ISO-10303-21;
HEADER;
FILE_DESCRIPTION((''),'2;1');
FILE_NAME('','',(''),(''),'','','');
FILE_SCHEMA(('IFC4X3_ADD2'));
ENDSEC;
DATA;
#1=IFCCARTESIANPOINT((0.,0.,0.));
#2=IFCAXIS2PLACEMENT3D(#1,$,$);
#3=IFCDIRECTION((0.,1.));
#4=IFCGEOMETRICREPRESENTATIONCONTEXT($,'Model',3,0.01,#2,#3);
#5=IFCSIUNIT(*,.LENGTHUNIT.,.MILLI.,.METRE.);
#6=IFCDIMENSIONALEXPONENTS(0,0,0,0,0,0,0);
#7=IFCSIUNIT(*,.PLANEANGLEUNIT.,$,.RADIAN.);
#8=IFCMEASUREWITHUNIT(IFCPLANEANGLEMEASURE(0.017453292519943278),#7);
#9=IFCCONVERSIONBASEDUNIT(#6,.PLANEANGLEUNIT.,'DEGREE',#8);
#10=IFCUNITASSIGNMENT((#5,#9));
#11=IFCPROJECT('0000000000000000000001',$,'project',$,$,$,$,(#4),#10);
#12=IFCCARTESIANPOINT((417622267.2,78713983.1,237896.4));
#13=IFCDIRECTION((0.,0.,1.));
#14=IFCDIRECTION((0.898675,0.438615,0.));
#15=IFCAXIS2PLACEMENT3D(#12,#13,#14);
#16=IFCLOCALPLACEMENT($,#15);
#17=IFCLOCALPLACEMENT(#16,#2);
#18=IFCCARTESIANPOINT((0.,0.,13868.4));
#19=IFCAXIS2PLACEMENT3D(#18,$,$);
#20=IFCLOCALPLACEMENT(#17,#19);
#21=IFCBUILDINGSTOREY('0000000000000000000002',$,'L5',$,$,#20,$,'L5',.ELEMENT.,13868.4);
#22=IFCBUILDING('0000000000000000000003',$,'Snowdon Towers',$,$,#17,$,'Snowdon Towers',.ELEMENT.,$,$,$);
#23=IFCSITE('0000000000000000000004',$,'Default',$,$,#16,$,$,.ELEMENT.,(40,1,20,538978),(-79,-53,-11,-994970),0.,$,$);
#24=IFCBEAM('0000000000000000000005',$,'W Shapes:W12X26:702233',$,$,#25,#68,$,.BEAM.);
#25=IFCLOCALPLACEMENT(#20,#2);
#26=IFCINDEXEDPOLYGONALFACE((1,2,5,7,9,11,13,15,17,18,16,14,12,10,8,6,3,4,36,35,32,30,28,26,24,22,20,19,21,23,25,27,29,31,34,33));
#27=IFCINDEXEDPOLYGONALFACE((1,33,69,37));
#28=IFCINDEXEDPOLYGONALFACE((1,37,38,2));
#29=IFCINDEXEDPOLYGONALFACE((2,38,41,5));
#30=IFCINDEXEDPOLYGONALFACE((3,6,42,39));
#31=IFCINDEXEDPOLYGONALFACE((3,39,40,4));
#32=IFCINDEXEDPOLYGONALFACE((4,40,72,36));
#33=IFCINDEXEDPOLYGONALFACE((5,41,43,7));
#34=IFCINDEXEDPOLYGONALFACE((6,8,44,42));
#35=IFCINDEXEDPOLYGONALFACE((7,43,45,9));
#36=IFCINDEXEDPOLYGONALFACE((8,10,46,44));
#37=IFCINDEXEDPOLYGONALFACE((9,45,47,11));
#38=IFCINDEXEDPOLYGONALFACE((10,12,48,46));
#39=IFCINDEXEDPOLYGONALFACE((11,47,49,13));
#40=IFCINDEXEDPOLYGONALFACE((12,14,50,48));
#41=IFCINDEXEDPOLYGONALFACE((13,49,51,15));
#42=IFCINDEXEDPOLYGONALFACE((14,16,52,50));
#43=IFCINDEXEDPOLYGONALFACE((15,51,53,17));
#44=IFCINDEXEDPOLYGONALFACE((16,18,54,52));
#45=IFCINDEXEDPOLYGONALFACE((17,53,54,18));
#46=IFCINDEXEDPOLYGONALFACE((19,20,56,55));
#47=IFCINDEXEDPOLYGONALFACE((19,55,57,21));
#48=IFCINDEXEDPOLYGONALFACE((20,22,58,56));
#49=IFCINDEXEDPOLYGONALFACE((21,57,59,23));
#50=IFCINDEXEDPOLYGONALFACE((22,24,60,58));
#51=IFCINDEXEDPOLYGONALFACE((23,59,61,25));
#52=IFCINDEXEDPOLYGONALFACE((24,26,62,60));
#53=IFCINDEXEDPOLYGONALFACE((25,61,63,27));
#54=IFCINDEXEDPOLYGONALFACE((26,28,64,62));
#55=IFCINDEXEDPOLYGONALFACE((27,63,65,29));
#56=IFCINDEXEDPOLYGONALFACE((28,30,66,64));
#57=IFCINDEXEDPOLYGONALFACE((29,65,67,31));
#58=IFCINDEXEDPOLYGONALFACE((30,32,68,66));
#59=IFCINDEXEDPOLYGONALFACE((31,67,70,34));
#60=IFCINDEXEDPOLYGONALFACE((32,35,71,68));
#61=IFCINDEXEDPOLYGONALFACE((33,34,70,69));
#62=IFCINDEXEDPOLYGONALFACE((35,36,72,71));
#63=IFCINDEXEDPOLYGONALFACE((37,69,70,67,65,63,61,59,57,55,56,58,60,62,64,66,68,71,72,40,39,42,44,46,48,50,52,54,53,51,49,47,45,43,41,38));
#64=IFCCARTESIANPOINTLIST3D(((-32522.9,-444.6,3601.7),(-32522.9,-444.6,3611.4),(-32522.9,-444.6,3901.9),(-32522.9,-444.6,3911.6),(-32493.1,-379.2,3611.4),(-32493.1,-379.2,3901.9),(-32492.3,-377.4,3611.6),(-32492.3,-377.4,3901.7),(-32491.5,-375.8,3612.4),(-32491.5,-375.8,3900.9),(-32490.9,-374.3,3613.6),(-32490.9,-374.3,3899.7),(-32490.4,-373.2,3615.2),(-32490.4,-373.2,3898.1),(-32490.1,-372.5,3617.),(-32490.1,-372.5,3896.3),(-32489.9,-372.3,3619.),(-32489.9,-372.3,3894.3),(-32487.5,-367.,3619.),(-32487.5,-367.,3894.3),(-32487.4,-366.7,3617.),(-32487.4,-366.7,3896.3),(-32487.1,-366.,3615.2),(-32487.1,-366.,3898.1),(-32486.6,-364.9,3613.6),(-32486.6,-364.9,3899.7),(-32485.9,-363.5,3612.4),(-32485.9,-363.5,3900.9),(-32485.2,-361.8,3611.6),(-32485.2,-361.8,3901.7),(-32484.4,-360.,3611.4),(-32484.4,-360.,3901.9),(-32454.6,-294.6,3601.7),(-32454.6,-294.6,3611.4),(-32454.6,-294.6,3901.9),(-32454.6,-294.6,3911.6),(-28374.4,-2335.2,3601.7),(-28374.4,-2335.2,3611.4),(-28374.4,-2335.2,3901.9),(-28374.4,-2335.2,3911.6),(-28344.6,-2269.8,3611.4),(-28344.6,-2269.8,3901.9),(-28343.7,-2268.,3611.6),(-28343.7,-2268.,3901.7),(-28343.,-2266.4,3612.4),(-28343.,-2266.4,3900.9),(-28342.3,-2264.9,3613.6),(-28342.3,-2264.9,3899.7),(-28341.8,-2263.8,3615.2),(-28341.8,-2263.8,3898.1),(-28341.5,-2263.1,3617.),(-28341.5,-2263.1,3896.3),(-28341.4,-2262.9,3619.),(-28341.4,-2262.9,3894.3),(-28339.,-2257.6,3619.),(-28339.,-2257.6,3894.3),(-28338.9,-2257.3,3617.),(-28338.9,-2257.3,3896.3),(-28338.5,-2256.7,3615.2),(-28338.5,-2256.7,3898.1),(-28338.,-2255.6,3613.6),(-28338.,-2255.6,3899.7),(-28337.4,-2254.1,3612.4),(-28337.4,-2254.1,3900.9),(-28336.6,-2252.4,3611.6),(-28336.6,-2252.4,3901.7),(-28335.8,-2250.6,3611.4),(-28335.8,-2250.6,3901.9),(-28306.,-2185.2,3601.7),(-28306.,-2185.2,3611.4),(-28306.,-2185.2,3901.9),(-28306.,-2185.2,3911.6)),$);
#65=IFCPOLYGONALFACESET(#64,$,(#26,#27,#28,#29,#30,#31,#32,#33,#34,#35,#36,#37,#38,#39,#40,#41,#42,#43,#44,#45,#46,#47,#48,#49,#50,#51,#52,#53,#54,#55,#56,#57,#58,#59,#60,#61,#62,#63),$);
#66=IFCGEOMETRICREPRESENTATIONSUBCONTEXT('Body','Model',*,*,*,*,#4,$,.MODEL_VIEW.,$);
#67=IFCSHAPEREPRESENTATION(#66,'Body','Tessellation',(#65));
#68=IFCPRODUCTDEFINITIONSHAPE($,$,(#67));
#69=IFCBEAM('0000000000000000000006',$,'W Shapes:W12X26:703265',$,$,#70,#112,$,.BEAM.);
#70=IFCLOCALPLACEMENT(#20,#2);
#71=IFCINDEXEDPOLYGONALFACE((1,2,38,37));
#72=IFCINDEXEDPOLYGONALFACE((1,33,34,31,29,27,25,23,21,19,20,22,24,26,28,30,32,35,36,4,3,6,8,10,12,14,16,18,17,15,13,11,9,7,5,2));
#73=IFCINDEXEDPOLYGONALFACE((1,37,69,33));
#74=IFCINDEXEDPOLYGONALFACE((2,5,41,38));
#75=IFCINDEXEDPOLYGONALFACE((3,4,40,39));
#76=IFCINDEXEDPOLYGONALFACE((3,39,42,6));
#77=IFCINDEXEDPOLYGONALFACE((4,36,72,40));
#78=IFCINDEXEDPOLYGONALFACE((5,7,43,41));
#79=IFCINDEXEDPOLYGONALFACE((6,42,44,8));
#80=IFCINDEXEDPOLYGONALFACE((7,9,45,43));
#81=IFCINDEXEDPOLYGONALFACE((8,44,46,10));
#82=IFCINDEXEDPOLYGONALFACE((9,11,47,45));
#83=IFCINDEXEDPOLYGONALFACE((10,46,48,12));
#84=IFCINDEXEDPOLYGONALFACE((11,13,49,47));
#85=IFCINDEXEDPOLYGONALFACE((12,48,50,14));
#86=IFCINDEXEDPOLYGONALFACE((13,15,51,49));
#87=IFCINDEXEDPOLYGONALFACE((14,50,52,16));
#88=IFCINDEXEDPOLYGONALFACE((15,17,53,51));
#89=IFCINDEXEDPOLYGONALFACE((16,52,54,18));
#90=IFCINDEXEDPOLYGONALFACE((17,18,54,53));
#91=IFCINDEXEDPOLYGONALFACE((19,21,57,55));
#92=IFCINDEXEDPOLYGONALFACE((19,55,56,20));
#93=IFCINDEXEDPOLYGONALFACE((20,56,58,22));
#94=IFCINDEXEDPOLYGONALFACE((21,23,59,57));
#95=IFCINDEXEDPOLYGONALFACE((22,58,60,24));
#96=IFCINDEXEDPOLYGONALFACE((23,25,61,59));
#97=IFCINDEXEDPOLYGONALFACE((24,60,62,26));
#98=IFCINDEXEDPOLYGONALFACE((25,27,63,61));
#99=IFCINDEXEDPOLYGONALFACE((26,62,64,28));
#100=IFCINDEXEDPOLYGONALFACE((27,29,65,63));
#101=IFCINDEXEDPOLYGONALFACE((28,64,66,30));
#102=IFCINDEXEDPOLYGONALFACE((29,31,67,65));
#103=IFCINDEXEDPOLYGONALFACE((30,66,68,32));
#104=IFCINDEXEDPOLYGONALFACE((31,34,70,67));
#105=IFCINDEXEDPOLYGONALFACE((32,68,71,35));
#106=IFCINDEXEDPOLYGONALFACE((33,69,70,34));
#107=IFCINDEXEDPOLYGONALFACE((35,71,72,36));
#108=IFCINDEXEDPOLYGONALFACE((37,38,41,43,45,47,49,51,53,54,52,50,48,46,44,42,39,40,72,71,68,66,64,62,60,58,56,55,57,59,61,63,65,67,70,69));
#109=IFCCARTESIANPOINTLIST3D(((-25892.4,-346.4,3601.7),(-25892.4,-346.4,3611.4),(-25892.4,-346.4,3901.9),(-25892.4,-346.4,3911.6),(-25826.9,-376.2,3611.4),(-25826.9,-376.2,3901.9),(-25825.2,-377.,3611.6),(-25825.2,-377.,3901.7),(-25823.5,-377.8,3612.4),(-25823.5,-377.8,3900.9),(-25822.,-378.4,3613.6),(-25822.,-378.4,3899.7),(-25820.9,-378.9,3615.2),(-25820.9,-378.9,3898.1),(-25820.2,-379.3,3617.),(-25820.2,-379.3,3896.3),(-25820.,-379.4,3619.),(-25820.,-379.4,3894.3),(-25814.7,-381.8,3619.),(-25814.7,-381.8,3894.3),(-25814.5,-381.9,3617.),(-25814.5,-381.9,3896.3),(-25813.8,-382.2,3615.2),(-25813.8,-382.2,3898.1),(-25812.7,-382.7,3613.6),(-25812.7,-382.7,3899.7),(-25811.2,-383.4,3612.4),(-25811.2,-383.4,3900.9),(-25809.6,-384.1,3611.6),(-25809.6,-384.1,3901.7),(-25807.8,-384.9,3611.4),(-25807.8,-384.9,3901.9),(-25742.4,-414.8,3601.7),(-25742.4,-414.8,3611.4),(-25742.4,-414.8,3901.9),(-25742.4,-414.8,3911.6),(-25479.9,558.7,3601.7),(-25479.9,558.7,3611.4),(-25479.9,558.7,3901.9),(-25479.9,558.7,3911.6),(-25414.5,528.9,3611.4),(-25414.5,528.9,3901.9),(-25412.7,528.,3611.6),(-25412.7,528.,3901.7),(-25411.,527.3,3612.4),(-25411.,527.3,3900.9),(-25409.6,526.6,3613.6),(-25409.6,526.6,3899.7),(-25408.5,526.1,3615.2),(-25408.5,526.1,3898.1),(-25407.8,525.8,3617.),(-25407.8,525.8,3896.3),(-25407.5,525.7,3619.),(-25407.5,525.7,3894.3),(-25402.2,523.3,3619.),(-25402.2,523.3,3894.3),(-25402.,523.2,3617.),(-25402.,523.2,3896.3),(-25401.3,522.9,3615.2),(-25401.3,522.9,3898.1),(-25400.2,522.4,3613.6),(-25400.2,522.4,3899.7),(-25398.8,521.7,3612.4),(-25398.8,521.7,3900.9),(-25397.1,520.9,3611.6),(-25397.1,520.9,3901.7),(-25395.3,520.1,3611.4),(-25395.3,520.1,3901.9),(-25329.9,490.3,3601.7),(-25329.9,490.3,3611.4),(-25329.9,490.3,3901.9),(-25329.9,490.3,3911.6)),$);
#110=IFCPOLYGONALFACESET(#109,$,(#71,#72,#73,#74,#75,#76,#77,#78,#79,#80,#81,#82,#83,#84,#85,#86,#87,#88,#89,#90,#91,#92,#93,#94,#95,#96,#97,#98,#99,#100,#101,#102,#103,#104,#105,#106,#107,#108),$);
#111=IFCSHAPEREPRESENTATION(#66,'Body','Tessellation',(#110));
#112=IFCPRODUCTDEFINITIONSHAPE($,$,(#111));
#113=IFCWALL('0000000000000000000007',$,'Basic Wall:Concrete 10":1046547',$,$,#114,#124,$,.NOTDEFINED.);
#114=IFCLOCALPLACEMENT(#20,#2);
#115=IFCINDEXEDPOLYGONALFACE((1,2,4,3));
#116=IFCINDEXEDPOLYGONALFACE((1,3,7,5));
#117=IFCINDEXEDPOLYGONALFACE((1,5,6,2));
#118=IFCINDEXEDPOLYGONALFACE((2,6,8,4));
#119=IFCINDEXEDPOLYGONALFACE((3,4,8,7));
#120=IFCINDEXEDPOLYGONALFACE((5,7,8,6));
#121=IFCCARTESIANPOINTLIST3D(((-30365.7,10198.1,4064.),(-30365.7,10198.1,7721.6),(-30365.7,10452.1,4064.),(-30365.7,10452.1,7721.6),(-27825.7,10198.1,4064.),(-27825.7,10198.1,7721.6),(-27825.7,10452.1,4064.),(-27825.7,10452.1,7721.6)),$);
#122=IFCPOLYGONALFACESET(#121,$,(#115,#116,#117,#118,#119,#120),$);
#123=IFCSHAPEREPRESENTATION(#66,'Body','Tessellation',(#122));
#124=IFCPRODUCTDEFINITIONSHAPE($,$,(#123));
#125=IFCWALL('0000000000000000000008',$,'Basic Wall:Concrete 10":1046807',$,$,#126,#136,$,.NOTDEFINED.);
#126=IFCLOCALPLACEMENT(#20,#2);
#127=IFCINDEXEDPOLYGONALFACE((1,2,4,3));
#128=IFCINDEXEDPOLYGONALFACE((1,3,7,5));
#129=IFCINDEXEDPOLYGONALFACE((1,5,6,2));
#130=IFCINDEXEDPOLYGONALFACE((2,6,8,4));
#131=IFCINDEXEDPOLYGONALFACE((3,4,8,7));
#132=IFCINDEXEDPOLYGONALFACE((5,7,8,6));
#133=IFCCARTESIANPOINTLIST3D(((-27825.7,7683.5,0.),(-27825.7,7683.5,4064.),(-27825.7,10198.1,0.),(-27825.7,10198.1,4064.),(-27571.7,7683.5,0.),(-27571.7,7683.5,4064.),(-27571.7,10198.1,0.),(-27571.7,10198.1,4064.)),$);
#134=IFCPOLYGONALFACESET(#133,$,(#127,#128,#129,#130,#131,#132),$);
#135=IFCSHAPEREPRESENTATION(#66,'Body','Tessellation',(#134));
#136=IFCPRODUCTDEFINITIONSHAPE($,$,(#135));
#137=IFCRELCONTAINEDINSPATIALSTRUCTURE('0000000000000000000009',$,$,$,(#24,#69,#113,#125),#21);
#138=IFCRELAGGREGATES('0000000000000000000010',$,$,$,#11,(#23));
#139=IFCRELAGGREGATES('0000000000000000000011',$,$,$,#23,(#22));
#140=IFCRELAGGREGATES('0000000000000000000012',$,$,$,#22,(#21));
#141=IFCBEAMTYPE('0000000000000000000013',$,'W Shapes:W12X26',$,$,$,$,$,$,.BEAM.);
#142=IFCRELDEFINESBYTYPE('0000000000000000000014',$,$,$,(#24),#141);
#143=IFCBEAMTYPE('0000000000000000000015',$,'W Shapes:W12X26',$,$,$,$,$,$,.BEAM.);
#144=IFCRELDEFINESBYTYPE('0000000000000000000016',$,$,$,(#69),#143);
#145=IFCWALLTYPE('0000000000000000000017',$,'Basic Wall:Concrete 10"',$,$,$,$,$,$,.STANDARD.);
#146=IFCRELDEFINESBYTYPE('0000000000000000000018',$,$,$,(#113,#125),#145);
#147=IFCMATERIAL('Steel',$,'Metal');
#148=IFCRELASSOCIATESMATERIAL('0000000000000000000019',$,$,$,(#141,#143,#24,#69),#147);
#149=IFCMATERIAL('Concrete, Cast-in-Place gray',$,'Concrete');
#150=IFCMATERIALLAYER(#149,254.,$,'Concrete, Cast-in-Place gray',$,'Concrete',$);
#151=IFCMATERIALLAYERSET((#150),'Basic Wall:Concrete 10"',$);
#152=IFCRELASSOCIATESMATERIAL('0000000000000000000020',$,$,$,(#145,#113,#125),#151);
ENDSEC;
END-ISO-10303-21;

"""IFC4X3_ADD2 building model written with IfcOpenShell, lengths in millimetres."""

from ifc_helpers import new_model, entity, si_unit, converted_unit, direction, frame, frame_2d, origin, place, context, subcontext, project, spatial, polyline, circle_curve, parameter, trimmed, segment, composite_curve, rectangle, outline, extrude, source, transform, mapped, material, layer, layer_set, material_profile, profile_set, profile_usage, type_object, type_shapes, element, save


model = new_model("IFC4X3_ADD2")

# Units and contexts
model_context = context("Model", 3, precision=0.01, world=origin(), true_north=direction((0.0, 1.0)))
body_context = subcontext(model_context, "Body", "Model", "MODEL_VIEW")
ifc_project = project(units=[si_unit("LENGTHUNIT", "METRE", prefix="MILLI"), converted_unit("PLANEANGLEUNIT", "DEGREE", entity("IfcPlaneAngleMeasure", 0.017453292519943278), si_unit("PLANEANGLEUNIT", "RADIAN"), dimensions=[0, 0, 0, 0, 0, 0, 0])], contexts=[model_context])

# Site, building, storey
site_placement = place(None, frame((417622267.2, 78713983.1, 237896.4), z_axis=(0.0, 0.0, 1.0), x_axis=(0.898675, 0.438615, 0.0)))
site = spatial("IfcSite", under=ifc_project, at=site_placement, Name="Default", CompositionType="ELEMENT", RefLatitude=(40, 1, 20, 538978), RefLongitude=(-79, -53, -11, -994970), RefElevation=0.0)
building_placement = place(site_placement, origin())
building = spatial("IfcBuilding", under=site, at=building_placement, Name="Snowdon Towers", LongName="Snowdon Towers", CompositionType="ELEMENT")
storey_placement = place(building_placement, frame((0.0, 0.0, 13868.4)))
storey = spatial("IfcBuildingStorey", under=building, at=storey_placement, Name="L5", LongName="L5", CompositionType="ELEMENT", Elevation=13868.4)

# Shared definitions
ifc_material_1 = material(Name="Steel", Category="Metal")

# Beams
ifc_material_profile_1 = material_profile(ifc_material_1, outline(composite_curve([segment(polyline([(-82.4, -145.3), (-82.4, -154.9)]), True, "CONTINUOUS"), segment(polyline([(-82.4, -154.9), (82.4, -154.9)]), True, "CONTINUOUS"), segment(polyline([(82.4, -154.9), (82.4, -145.3)]), True, "CONTINUOUS"), segment(polyline([(82.4, -145.3), (10.5, -145.3)]), True, "CONTINUOUS"), segment(trimmed(circle_curve(frame_2d((10.5, -137.7), x_axis=(1.0, 0.0)), 7.6), [parameter(180.0)], [parameter(270.0)], True, "PARAMETER"), False, "CONTINUOUS"), segment(polyline([(2.9, -137.7), (2.9, 137.7)]), True, "CONTINUOUS"), segment(trimmed(circle_curve(frame_2d((10.5, 137.7), x_axis=(1.0, 0.0)), 7.6), [parameter(90.0)], [parameter(180.0)], True, "PARAMETER"), False, "CONTINUOUS"), segment(polyline([(10.5, 145.3), (82.4, 145.3)]), True, "CONTINUOUS"), segment(polyline([(82.4, 145.3), (82.4, 154.9)]), True, "CONTINUOUS"), segment(polyline([(82.4, 154.9), (-82.4, 154.9)]), True, "CONTINUOUS"), segment(polyline([(-82.4, 154.9), (-82.4, 145.3)]), True, "CONTINUOUS"), segment(polyline([(-82.4, 145.3), (-10.5, 145.3)]), True, "CONTINUOUS"), segment(trimmed(circle_curve(frame_2d((-10.5, 137.7), x_axis=(1.0, 0.0)), 7.6), [parameter(360.0)], [parameter(90.0)], True, "PARAMETER"), False, "CONTINUOUS"), segment(polyline([(-2.9, 137.7), (-2.9, -137.7)]), True, "CONTINUOUS"), segment(trimmed(circle_curve(frame_2d((-10.5, -137.7), x_axis=(1.0, 0.0)), 7.6), [parameter(270.0)], [parameter(360.0)], True, "PARAMETER"), False, "CONTINUOUS"), segment(polyline([(-10.5, -145.3), (-82.4, -145.3)]), True, "CONTINUOUS")], self_intersect=False)), Name="W12X26")
ifc_profile_set_1 = profile_set([ifc_material_profile_1], Name="W12X26")
ifc_profile_usage_1 = profile_usage(ifc_profile_set_1, cardinal=8)
beam_type_1 = type_object("IfcBeamType", Name="W Shapes:W12X26", PredefinedType="BEAM", material=ifc_profile_set_1)
shared_shape_1 = source(origin(), body_context, "Body", "SweptSolid", [
    extrude(outline(composite_curve([segment(polyline([(-82.4, -145.3), (-82.4, -154.9)]), True, "CONTINUOUS"), segment(polyline([(-82.4, -154.9), (82.4, -154.9)]), True, "CONTINUOUS"), segment(polyline([(82.4, -154.9), (82.4, -145.3)]), True, "CONTINUOUS"), segment(polyline([(82.4, -145.3), (10.5, -145.3)]), True, "CONTINUOUS"), segment(trimmed(circle_curve(frame_2d((10.5, -137.7), x_axis=(1.0, 0.0)), 7.6), [parameter(180.0)], [parameter(270.0)], True, "PARAMETER"), False, "CONTINUOUS"), segment(polyline([(2.9, -137.7), (2.9, 137.7)]), True, "CONTINUOUS"), segment(trimmed(circle_curve(frame_2d((10.5, 137.7), x_axis=(1.0, 0.0)), 7.6), [parameter(90.0)], [parameter(180.0)], True, "PARAMETER"), False, "CONTINUOUS"), segment(polyline([(10.5, 145.3), (82.4, 145.3)]), True, "CONTINUOUS"), segment(polyline([(82.4, 145.3), (82.4, 154.9)]), True, "CONTINUOUS"), segment(polyline([(82.4, 154.9), (-82.4, 154.9)]), True, "CONTINUOUS"), segment(polyline([(-82.4, 154.9), (-82.4, 145.3)]), True, "CONTINUOUS"), segment(polyline([(-82.4, 145.3), (-10.5, 145.3)]), True, "CONTINUOUS"), segment(trimmed(circle_curve(frame_2d((-10.5, 137.7), x_axis=(1.0, 0.0)), 7.6), [parameter(360.0)], [parameter(90.0)], True, "PARAMETER"), False, "CONTINUOUS"), segment(polyline([(-2.9, 137.7), (-2.9, -137.7)]), True, "CONTINUOUS"), segment(trimmed(circle_curve(frame_2d((-10.5, -137.7), x_axis=(1.0, 0.0)), 7.6), [parameter(270.0)], [parameter(360.0)], True, "PARAMETER"), False, "CONTINUOUS"), segment(polyline([(-10.5, -145.3), (-82.4, -145.3)]), True, "CONTINUOUS")], self_intersect=False)), frame((-2279.5, 0.0, 0.0), z_axis=(-1.0, 0.0, 0.0), x_axis=(0.0, -1.0, 0.0)), (0.0, 0.0, -1.0), 4559.0),
])
type_shapes(beam_type_1, [shared_shape_1])
beam_1_placement = place(storey_placement, frame((-30414.5, -1314.9, 3756.7), z_axis=(0.0, 0.0, 1.0), x_axis=(0.909961, -0.414693, 0.0)))
element("IfcBeam", 1, at=beam_1_placement, inside=storey, type_object=beam_type_1, material=ifc_profile_usage_1, Name="W Shapes:W12X26:702233", PredefinedType="BEAM", context=body_context, shape_type="MappedRepresentation", body=[
    mapped(shared_shape_1, transform((0.0, 0.0, 0.0), scale=1.0)),
])
beam_type_2 = type_object("IfcBeamType", Name="W Shapes:W12X26", PredefinedType="BEAM", material=ifc_profile_set_1)
shared_shape_2 = source(origin(), body_context, "Body", "SweptSolid", [
    extrude(outline(composite_curve([segment(polyline([(-82.4, -145.3), (-82.4, -154.9)]), True, "CONTINUOUS"), segment(polyline([(-82.4, -154.9), (82.4, -154.9)]), True, "CONTINUOUS"), segment(polyline([(82.4, -154.9), (82.4, -145.3)]), True, "CONTINUOUS"), segment(polyline([(82.4, -145.3), (10.5, -145.3)]), True, "CONTINUOUS"), segment(trimmed(circle_curve(frame_2d((10.5, -137.7), x_axis=(0.0, -1.0)), 7.6), [parameter(270.0)], [parameter(360.0)], True, "PARAMETER"), False, "CONTINUOUS"), segment(polyline([(2.9, -137.7), (2.9, 137.7)]), True, "CONTINUOUS"), segment(trimmed(circle_curve(frame_2d((10.5, 137.7), x_axis=(-1.0, 0.0)), 7.6), [parameter(270.0)], [parameter(360.0)], True, "PARAMETER"), False, "CONTINUOUS"), segment(polyline([(10.5, 145.3), (82.4, 145.3)]), True, "CONTINUOUS"), segment(polyline([(82.4, 145.3), (82.4, 154.9)]), True, "CONTINUOUS"), segment(polyline([(82.4, 154.9), (-82.4, 154.9)]), True, "CONTINUOUS"), segment(polyline([(-82.4, 154.9), (-82.4, 145.3)]), True, "CONTINUOUS"), segment(polyline([(-82.4, 145.3), (-10.5, 145.3)]), True, "CONTINUOUS"), segment(trimmed(circle_curve(frame_2d((-10.5, 137.7), x_axis=(0.0, 1.0)), 7.6), [parameter(270.0)], [parameter(0.0)], True, "PARAMETER"), False, "CONTINUOUS"), segment(polyline([(-2.9, 137.7), (-2.9, -137.7)]), True, "CONTINUOUS"), segment(trimmed(circle_curve(frame_2d((-10.5, -137.7), x_axis=(1.0, 0.0)), 7.6), [parameter(270.0)], [parameter(0.0)], True, "PARAMETER"), False, "CONTINUOUS"), segment(polyline([(-10.5, -145.3), (-82.4, -145.3)]), True, "CONTINUOUS")], self_intersect=False)), frame((-580.3, 0.0, 0.0), z_axis=(-1.0, 0.0, 0.0), x_axis=(0.0, -1.0, 0.0)), (0.0, 0.0, -1.0), 994.6),
])
type_shapes(beam_type_2, [shared_shape_2])
beam_2_placement = place(storey_placement, frame((-25576.7, 147.4, 3756.7), z_axis=(0.0, 0.0, 1.0), x_axis=(0.414693, 0.909961, 0.0)))
element("IfcBeam", 2, at=beam_2_placement, inside=storey, type_object=beam_type_2, material=ifc_profile_usage_1, Name="W Shapes:W12X26:703265", PredefinedType="BEAM", context=body_context, shape_type="MappedRepresentation", body=[
    mapped(shared_shape_2, transform((0.0, 0.0, 0.0), scale=1.0)),
])

# Walls
ifc_material_2 = material(Name="Concrete, Cast-in-Place gray", Category="Concrete")
ifc_layer_1 = layer(ifc_material_2, 254.0, Name="Concrete, Cast-in-Place gray", Category="Concrete")
ifc_layer_set_1 = layer_set([ifc_layer_1], Name="Basic Wall:Concrete 10\"")
wall_type_1 = type_object("IfcWallType", Name="Basic Wall:Concrete 10\"", PredefinedType="STANDARD", material=ifc_layer_set_1)
wall_1_placement = place(storey_placement, frame((-30365.7, 10325.1, 4064.0)))
element("IfcWall", 3, at=wall_1_placement, inside=storey, type_object=wall_type_1, material=ifc_layer_set_1, Name="Basic Wall:Concrete 10\":1046547", PredefinedType="NOTDEFINED", context=body_context, shape_type="SweptSolid", body=[
    extrude(rectangle(XDim=2540.0, YDim=254.0, at=frame_2d((1270.0, 0.0), x_axis=(-1.0, 0.0))), origin(), (0.0, 0.0, 1.0), 3657.6),
])
wall_2_placement = place(storey_placement, frame((-27698.7, 10198.1, 0.0), z_axis=(0.0, 0.0, 1.0), x_axis=(0.0, -1.0, 0.0)))
element("IfcWall", 4, at=wall_2_placement, inside=storey, type_object=wall_type_1, material=ifc_layer_set_1, Name="Basic Wall:Concrete 10\":1046807", PredefinedType="NOTDEFINED", context=body_context, shape_type="SweptSolid", body=[
    extrude(rectangle(XDim=2514.6, YDim=254.0, at=frame_2d((1257.3, 0.0), x_axis=(-1.0, 0.0))), origin(), (0.0, 0.0, 1.0), 4064.0),
])

save(model, "model.ifc")
